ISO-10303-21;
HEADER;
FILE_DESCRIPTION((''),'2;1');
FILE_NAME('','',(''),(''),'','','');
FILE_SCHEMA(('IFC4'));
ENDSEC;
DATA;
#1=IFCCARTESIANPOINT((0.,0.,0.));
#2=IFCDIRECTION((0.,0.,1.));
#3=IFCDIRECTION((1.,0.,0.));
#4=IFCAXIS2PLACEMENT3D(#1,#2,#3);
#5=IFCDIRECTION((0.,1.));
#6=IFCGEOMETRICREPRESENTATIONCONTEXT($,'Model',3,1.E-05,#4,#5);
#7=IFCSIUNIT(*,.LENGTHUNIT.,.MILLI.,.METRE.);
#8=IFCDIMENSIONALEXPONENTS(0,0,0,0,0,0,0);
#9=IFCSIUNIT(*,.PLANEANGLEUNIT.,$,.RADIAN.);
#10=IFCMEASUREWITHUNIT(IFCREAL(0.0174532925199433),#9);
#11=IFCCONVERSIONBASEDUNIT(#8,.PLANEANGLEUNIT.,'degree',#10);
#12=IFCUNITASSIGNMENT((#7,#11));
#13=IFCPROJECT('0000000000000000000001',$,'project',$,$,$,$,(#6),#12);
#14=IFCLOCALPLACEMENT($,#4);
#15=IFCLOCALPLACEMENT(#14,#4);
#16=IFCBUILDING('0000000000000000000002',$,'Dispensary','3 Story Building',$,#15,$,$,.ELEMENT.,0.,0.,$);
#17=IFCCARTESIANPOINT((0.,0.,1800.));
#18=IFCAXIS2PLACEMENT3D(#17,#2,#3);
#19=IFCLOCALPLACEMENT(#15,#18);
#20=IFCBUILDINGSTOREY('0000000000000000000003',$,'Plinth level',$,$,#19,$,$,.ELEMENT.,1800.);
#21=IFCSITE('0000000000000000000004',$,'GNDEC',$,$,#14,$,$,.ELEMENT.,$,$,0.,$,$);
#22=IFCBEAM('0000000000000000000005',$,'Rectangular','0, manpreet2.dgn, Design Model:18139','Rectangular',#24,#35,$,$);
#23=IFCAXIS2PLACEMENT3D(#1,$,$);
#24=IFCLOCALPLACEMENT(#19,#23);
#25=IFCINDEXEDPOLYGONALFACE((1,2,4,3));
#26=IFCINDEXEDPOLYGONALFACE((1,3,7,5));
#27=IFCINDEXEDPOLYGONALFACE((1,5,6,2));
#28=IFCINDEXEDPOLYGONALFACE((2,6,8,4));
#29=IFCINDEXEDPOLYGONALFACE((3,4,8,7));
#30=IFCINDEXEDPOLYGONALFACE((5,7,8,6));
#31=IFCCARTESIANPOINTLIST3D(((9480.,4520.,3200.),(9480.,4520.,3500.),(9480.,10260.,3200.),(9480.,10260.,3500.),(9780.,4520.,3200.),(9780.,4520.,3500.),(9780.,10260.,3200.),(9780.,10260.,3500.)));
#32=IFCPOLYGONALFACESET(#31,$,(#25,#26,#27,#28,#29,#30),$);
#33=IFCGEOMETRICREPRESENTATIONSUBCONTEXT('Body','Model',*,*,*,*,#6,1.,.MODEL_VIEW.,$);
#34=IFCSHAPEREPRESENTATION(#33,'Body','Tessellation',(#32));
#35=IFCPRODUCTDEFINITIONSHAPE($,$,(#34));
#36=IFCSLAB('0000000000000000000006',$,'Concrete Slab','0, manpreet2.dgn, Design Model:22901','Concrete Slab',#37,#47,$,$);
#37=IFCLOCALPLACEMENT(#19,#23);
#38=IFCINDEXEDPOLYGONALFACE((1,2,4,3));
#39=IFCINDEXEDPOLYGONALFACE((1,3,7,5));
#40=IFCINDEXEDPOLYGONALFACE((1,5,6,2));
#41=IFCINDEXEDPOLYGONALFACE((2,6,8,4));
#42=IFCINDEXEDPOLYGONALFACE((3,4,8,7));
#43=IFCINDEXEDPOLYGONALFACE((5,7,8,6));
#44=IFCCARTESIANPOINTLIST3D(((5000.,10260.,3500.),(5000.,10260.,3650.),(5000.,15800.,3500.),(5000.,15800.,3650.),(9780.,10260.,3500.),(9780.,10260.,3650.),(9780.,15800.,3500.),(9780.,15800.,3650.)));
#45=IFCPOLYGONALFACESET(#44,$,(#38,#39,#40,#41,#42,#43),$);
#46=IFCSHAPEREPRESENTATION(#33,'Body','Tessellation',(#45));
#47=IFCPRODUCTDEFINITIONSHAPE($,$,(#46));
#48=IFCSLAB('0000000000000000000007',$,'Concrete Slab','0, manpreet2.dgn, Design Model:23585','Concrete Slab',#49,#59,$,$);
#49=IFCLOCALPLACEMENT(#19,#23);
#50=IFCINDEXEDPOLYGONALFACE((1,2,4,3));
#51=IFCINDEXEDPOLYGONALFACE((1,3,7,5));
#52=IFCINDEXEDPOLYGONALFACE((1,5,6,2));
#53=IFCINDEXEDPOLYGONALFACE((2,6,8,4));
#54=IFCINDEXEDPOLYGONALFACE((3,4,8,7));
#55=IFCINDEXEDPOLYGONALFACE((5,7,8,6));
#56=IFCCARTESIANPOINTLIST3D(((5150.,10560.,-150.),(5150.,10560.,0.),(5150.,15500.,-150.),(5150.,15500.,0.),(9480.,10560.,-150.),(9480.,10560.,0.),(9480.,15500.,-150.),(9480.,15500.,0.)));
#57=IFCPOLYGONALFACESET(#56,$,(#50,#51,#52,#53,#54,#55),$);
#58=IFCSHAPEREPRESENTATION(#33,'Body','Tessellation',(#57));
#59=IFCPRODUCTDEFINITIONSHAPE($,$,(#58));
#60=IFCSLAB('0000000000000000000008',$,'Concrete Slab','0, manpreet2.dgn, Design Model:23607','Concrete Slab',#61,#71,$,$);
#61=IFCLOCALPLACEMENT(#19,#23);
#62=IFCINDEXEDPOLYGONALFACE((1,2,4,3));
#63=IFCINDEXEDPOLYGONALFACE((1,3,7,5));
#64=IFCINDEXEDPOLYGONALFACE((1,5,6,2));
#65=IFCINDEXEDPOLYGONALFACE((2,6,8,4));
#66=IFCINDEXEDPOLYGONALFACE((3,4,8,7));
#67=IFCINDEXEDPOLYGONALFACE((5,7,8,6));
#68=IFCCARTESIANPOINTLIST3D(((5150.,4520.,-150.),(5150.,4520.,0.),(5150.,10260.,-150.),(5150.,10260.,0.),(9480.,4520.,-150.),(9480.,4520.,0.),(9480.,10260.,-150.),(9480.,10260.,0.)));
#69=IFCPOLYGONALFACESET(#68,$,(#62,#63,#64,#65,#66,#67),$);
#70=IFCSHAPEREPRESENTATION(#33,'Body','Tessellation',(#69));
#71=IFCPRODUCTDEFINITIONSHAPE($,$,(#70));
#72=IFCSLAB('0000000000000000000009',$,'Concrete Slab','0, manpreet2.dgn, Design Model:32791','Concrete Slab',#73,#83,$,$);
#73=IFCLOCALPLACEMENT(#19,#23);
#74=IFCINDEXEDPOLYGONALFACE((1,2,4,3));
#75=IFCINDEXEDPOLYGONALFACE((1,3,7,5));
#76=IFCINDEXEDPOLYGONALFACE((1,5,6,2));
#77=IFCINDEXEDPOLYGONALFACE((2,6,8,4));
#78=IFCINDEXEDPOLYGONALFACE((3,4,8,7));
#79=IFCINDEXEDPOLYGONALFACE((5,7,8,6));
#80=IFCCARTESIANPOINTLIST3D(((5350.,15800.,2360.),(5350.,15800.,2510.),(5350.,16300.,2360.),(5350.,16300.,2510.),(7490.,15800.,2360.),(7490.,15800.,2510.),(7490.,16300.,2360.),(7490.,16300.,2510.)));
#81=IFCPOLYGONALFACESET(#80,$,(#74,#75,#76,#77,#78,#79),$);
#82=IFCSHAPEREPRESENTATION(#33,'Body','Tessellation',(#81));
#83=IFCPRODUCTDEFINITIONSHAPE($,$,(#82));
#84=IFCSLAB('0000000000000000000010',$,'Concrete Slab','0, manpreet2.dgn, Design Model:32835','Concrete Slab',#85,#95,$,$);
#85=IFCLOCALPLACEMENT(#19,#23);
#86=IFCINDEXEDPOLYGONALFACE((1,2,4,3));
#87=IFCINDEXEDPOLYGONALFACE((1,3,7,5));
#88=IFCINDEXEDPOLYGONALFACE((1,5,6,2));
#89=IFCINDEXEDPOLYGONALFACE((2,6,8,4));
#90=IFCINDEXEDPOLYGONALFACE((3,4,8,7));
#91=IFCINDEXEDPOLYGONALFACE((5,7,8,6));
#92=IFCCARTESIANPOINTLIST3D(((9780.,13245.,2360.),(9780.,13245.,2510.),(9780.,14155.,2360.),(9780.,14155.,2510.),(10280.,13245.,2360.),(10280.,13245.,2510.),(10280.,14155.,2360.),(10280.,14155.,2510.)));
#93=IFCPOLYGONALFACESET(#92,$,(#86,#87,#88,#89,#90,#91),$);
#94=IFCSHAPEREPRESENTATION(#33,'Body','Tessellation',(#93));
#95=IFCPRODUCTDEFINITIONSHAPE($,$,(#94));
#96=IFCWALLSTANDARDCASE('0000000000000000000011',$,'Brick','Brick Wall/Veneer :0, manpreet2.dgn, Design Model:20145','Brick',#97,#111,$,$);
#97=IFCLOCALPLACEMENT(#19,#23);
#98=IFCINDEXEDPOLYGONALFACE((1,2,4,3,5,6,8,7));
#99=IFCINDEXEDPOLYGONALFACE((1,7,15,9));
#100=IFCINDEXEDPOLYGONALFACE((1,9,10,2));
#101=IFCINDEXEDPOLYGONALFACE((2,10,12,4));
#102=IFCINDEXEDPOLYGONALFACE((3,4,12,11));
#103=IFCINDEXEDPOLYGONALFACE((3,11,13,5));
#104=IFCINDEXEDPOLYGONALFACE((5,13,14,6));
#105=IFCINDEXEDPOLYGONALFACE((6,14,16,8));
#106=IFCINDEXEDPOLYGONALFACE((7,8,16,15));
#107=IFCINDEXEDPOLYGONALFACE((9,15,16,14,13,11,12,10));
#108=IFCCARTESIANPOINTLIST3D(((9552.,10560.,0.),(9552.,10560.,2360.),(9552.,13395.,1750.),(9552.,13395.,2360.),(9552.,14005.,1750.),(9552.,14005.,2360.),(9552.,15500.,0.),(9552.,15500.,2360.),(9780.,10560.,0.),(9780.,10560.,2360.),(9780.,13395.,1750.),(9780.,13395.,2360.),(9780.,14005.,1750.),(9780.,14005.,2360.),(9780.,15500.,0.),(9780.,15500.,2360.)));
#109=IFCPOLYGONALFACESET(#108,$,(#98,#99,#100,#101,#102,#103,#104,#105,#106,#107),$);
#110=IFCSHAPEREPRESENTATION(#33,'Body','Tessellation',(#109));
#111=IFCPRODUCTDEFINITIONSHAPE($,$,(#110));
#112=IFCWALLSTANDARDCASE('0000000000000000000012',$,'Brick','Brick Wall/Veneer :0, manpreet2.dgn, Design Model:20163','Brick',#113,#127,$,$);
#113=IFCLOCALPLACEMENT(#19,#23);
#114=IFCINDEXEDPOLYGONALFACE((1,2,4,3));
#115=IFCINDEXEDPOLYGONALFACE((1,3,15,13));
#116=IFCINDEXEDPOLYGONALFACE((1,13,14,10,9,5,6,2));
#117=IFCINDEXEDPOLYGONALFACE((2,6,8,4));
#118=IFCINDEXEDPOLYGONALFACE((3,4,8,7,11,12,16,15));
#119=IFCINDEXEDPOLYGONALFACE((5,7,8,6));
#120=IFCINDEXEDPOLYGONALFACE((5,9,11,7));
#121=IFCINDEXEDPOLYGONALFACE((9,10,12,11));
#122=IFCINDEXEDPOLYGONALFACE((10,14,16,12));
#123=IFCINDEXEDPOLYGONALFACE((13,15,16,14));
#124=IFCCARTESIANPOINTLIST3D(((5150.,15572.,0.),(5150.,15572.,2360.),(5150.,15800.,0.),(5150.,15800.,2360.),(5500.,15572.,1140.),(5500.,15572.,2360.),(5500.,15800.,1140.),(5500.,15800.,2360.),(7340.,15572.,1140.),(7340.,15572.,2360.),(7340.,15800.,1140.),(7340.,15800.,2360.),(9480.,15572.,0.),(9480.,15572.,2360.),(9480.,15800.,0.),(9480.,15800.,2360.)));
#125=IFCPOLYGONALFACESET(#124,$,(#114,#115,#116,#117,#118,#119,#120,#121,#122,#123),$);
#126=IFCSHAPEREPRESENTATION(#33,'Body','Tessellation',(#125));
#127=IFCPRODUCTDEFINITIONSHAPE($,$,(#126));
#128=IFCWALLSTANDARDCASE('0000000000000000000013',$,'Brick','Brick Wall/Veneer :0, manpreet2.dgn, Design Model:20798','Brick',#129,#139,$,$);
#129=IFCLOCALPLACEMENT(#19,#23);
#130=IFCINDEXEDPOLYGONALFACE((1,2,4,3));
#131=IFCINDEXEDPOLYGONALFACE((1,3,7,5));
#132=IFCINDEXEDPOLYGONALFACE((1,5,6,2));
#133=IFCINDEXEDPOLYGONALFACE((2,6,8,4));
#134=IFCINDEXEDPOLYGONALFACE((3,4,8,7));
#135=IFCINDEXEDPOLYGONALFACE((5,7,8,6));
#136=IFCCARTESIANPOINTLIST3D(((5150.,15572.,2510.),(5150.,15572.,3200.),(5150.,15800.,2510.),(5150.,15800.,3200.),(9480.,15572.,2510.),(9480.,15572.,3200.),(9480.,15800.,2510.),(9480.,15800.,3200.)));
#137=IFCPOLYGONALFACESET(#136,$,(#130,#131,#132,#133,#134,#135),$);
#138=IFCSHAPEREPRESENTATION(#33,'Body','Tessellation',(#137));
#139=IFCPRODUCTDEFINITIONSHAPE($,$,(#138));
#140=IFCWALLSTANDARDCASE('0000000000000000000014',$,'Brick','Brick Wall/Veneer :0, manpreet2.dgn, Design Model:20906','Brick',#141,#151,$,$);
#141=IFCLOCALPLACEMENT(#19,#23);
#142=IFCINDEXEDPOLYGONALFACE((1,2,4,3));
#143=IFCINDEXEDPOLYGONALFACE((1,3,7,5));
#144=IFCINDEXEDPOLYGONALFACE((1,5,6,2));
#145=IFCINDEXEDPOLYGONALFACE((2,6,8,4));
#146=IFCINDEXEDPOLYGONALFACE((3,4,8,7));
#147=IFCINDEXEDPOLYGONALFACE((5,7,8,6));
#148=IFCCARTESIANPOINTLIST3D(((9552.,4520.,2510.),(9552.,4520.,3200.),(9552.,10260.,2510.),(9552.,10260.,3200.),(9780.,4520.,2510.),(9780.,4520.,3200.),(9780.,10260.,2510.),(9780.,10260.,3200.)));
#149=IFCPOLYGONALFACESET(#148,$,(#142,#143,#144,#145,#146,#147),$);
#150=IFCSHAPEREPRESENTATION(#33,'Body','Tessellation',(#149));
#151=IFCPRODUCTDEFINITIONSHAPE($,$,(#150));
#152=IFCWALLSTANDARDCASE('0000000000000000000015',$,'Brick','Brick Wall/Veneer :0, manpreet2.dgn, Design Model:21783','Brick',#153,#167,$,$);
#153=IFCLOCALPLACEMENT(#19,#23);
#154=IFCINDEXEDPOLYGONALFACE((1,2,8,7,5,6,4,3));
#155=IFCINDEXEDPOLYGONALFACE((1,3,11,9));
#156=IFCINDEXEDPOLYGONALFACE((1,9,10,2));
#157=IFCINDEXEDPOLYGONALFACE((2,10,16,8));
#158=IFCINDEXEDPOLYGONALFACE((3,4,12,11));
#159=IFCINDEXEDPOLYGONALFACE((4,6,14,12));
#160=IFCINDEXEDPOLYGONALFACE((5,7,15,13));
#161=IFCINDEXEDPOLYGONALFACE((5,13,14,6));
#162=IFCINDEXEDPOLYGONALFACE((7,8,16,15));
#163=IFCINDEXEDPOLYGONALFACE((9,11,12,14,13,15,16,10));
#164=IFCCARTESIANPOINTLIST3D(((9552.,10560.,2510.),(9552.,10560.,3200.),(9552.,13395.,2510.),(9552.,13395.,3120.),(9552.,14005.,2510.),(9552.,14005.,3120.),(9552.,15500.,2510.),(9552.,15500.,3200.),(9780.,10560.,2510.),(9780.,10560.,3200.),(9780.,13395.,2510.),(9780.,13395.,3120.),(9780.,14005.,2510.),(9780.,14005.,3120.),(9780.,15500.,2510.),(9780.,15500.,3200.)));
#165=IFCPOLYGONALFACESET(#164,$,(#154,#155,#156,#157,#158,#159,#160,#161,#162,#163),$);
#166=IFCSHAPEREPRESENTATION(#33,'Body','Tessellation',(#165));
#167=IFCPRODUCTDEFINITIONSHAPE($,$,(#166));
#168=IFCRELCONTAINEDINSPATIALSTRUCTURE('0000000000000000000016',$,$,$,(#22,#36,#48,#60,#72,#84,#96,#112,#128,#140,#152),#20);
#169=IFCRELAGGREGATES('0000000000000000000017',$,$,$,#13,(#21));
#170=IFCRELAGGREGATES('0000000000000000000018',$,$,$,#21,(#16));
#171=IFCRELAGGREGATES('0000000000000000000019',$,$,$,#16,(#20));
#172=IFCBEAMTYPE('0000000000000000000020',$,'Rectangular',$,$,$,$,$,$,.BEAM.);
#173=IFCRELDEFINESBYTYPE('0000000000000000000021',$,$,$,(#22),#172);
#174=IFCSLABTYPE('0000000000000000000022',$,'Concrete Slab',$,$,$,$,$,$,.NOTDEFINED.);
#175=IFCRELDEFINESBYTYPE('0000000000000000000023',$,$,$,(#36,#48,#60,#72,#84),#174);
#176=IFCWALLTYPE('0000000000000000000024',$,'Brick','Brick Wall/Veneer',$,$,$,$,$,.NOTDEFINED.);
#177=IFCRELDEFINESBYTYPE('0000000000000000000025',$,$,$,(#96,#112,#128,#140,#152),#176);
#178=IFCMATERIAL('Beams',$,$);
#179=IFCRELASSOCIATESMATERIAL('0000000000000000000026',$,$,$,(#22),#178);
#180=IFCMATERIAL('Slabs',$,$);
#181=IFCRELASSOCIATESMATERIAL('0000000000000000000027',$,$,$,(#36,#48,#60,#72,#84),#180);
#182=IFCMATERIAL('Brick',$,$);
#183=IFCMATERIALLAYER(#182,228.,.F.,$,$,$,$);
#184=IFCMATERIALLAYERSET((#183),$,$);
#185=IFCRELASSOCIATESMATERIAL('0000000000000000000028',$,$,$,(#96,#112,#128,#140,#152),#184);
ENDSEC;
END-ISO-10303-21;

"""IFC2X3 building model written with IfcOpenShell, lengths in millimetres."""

from ifc_helpers import new_model, entity, si_unit, converted_unit, direction, frame, frame_2d, origin_with_axes, place, context, subcontext, project, spatial, rectangle, extrude, material, layer, layer_set, layer_usage, type_object, element, save


model = new_model("IFC2X3")

# Units and contexts
model_context = context("Model", 3, precision=1e-05, world=origin_with_axes(), true_north=direction((0.0, 1.0)))
body_context = subcontext(model_context, "Body", "Model", "MODEL_VIEW", scale=1.0)
ifc_project = project(units=[si_unit("LENGTHUNIT", "METRE", prefix="MILLI"), converted_unit("PLANEANGLEUNIT", "degree", entity("IfcReal", 0.0174532925199433), si_unit("PLANEANGLEUNIT", "RADIAN"), dimensions=[0, 0, 0, 0, 0, 0, 0])], contexts=[model_context])

# Site, building, storey
site_placement = place(None, origin_with_axes())
site = spatial("IfcSite", under=ifc_project, at=site_placement, Name="GNDEC", CompositionType="ELEMENT", RefElevation=0.0)
building_placement = place(site_placement, origin_with_axes())
building = spatial("IfcBuilding", under=site, at=building_placement, Name="Dispensary", Description="3 Story Building", CompositionType="ELEMENT", ElevationOfRefHeight=0.0, ElevationOfTerrain=0.0)
storey_placement = place(building_placement, frame((0.0, 0.0, 1800.0), z_axis=(0.0, 0.0, 1.0), x_axis=(1.0, 0.0, 0.0)))
storey = spatial("IfcBuildingStorey", under=building, at=storey_placement, Name="Plinth level", CompositionType="ELEMENT", Elevation=1800.0)

# Beam
ifc_material_1 = material(Name="Beams")
beam_type = type_object("IfcBeamType", Name="Rectangular", PredefinedType="BEAM")
beam_1_placement = place(storey_placement, frame((9480.0, 10260.0, 3200.0), z_axis=(0.0, -1.0, 0.0), x_axis=(1.0, 0.0, 0.0)))
element("IfcBeam", 1, at=beam_1_placement, inside=storey, type_object=beam_type, material=ifc_material_1, Name="Rectangular", Description="0, manpreet2.dgn, Design Model:18139", ObjectType="Rectangular", context=body_context, shape_type="SweptSolid", body=[
    extrude(rectangle(XDim=300.0, YDim=300.0, at=frame_2d((150.0, 150.0), x_axis=(0.0, 1.0))), origin_with_axes(), (0.0, 0.0, 1.0), 5740.0),
])

# Slabs
ifc_material_2 = material(Name="Slabs")
slab_type = type_object("IfcSlabType", Name="Concrete Slab", PredefinedType="NOTDEFINED")
slab_1_placement = place(storey_placement, frame((5000.0, 10260.0, 3500.0), z_axis=(0.0, 0.0, 1.0), x_axis=(1.0, 0.0, 0.0)))
element("IfcSlab", 2, at=slab_1_placement, inside=storey, type_object=slab_type, material=ifc_material_2, Name="Concrete Slab", Description="0, manpreet2.dgn, Design Model:22901", ObjectType="Concrete Slab", context=body_context, shape_type="SweptSolid", body=[
    extrude(rectangle(XDim=4780.0, YDim=5540.0, at=frame_2d((2390.0, 2770.0), x_axis=(1.0, 0.0))), origin_with_axes(), (0.0, 0.0, 1.0), 150.0),
])
slab_2_placement = place(storey_placement, frame((5150.0, 15500.0, 0.0), z_axis=(0.0, 0.0, -1.0), x_axis=(1.0, 0.0, 0.0)))
element("IfcSlab", 3, at=slab_2_placement, inside=storey, type_object=slab_type, material=ifc_material_2, Name="Concrete Slab", Description="0, manpreet2.dgn, Design Model:23585", ObjectType="Concrete Slab", context=body_context, shape_type="SweptSolid", body=[
    extrude(rectangle(XDim=4330.0, YDim=4940.0, at=frame_2d((2165.0, 2470.0), x_axis=(1.0, 0.0))), origin_with_axes(), (0.0, 0.0, 1.0), 150.0),
])
slab_3_placement = place(storey_placement, frame((5150.0, 10260.0, 0.0), z_axis=(0.0, 0.0, -1.0), x_axis=(1.0, 0.0, 0.0)))
element("IfcSlab", 4, at=slab_3_placement, inside=storey, type_object=slab_type, material=ifc_material_2, Name="Concrete Slab", Description="0, manpreet2.dgn, Design Model:23607", ObjectType="Concrete Slab", context=body_context, shape_type="SweptSolid", body=[
    extrude(rectangle(XDim=4330.0, YDim=5740.0, at=frame_2d((2165.0, 2870.0), x_axis=(1.0, 0.0))), origin_with_axes(), (0.0, 0.0, 1.0), 150.0),
])
slab_4_placement = place(storey_placement, frame((5500.0, 15800.0, 2510.0), z_axis=(0.0, 0.0, -1.0), x_axis=(-1.0, 0.0, 0.0)))
element("IfcSlab", 5, at=slab_4_placement, inside=storey, type_object=slab_type, material=ifc_material_2, Name="Concrete Slab", Description="0, manpreet2.dgn, Design Model:32791", ObjectType="Concrete Slab", context=body_context, shape_type="SweptSolid", body=[
    extrude(rectangle(XDim=500.0, YDim=2140.0, at=frame_2d((-920.0, 250.0), x_axis=(0.0, 1.0))), origin_with_axes(), (0.0, 0.0, 1.0), 150.0),
])
slab_5_placement = place(storey_placement, frame((9780.0, 14005.0, 2510.0), z_axis=(0.0, 0.0, -1.0), x_axis=(0.0, 1.0, 0.0)))
element("IfcSlab", 6, at=slab_5_placement, inside=storey, type_object=slab_type, material=ifc_material_2, Name="Concrete Slab", Description="0, manpreet2.dgn, Design Model:32835", ObjectType="Concrete Slab", context=body_context, shape_type="SweptSolid", body=[
    extrude(rectangle(XDim=500.0, YDim=910.0, at=frame_2d((-305.0, 250.0), x_axis=(0.0, 1.0))), origin_with_axes(), (0.0, 0.0, 1.0), 150.0),
])

# Walls, openings
ifc_material_3 = material(Name="Brick")
ifc_layer_1 = layer(ifc_material_3, 228.0, ventilated=False)
ifc_layer_set_1 = layer_set([ifc_layer_1])
ifc_layer_usage_1 = layer_usage(ifc_layer_set_1, "AXIS2", "POSITIVE", 0.0)
wall_type = type_object("IfcWallType", Name="Brick", Description="Brick Wall/Veneer", PredefinedType="NOTDEFINED")
wall_1_placement = place(storey_placement, frame((9780.0, 10560.0, 0.0), z_axis=(0.0, 0.0, 1.0), x_axis=(0.0, 1.0, 0.0)))
wall_1 = element("IfcWallStandardCase", 7, at=wall_1_placement, inside=storey, type_object=wall_type, material=ifc_layer_usage_1, Name="Brick", Description="Brick Wall/Veneer :0, manpreet2.dgn, Design Model:20145", ObjectType="Brick", context=body_context, shape_type="SweptSolid", body=[
    extrude(rectangle(XDim=4940.0, YDim=228.0, at=frame_2d((2470.0, 114.0), x_axis=(-1.0, 0.0))), origin_with_axes(), (0.0, 0.0, 1.0), 2360.0),
])
opening_1_placement = place(wall_1_placement, frame((2835.0, 0.0, 1750.0), z_axis=(0.0, 0.0, 1.0), x_axis=(1.0, 0.0, 0.0)))
element("IfcOpeningElement", 8, at=opening_1_placement, cuts=wall_1, ObjectType="Opening", context=body_context, shape_type="SweptSolid", body=[
    extrude(rectangle(XDim=1370.0, YDim=610.0, at=frame_2d((-305.0, 685.0), x_axis=(0.0, -1.0))), frame((0.0, 0.0, 0.0), z_axis=(0.0, 1.0, 0.0), x_axis=(-1.0, 0.0, 0.0)), (0.0, 0.0, 1.0), 228.0),
])
wall_2_placement = place(storey_placement, frame((9480.0, 15800.0, 0.0), z_axis=(0.0, 0.0, 1.0), x_axis=(-1.0, 0.0, 0.0)))
wall_2 = element("IfcWallStandardCase", 9, at=wall_2_placement, inside=storey, type_object=wall_type, material=ifc_layer_usage_1, Name="Brick", Description="Brick Wall/Veneer :0, manpreet2.dgn, Design Model:20163", ObjectType="Brick", context=body_context, shape_type="SweptSolid", body=[
    extrude(rectangle(XDim=4330.0, YDim=228.0, at=frame_2d((2165.0, 114.0), x_axis=(-1.0, 0.0))), origin_with_axes(), (0.0, 0.0, 1.0), 2360.0),
])
opening_2_placement = place(wall_2_placement, frame((2140.0, 0.0, 1140.0), z_axis=(0.0, 0.0, 1.0), x_axis=(1.0, 0.0, 0.0)))
element("IfcOpeningElement", 10, at=opening_2_placement, cuts=wall_2, ObjectType="Opening", context=body_context, shape_type="SweptSolid", body=[
    extrude(rectangle(XDim=1220.0, YDim=1840.0, at=frame_2d((-920.0, 610.0), x_axis=(0.0, -1.0))), frame((0.0, 0.0, 0.0), z_axis=(0.0, 1.0, 0.0), x_axis=(-1.0, 0.0, 0.0)), (0.0, 0.0, 1.0), 228.0),
])

# Walls
wall_3_placement = place(storey_placement, frame((5150.0, 15800.0, 2510.0), z_axis=(0.0, 0.0, 1.0), x_axis=(1.0, 0.0, 0.0)))
element("IfcWallStandardCase", 11, at=wall_3_placement, inside=storey, type_object=wall_type, material=ifc_layer_usage_1, Name="Brick", Description="Brick Wall/Veneer :0, manpreet2.dgn, Design Model:20798", ObjectType="Brick", context=body_context, shape_type="SweptSolid", body=[
    extrude(rectangle(XDim=4330.0, YDim=228.0, at=frame_2d((2165.0, -114.0), x_axis=(-1.0, 0.0))), origin_with_axes(), (0.0, 0.0, 1.0), 690.0),
])
wall_4_placement = place(storey_placement, frame((9780.0, 10260.0, 2510.0), z_axis=(0.0, 0.0, 1.0), x_axis=(0.0, -1.0, 0.0)))
element("IfcWallStandardCase", 12, at=wall_4_placement, inside=storey, type_object=wall_type, material=ifc_layer_usage_1, Name="Brick", Description="Brick Wall/Veneer :0, manpreet2.dgn, Design Model:20906", ObjectType="Brick", context=body_context, shape_type="SweptSolid", body=[
    extrude(rectangle(XDim=5740.0, YDim=228.0, at=frame_2d((2870.0, -114.0), x_axis=(-1.0, 0.0))), origin_with_axes(), (0.0, 0.0, 1.0), 690.0),
])

# Wall, opening
wall_5_placement = place(storey_placement, frame((9780.0, 15500.0, 2510.0), z_axis=(0.0, 0.0, 1.0), x_axis=(0.0, -1.0, 0.0)))
wall_5 = element("IfcWallStandardCase", 13, at=wall_5_placement, inside=storey, type_object=wall_type, material=ifc_layer_usage_1, Name="Brick", Description="Brick Wall/Veneer :0, manpreet2.dgn, Design Model:21783", ObjectType="Brick", context=body_context, shape_type="SweptSolid", body=[
    extrude(rectangle(XDim=4940.0, YDim=228.0, at=frame_2d((2470.0, -114.0), x_axis=(-1.0, 0.0))), origin_with_axes(), (0.0, 0.0, 1.0), 690.0),
])
opening_3_placement = place(wall_5_placement, frame((1495.0, -228.0, -760.0), z_axis=(0.0, 0.0, 1.0), x_axis=(1.0, 0.0, 0.0)))
element("IfcOpeningElement", 14, at=opening_3_placement, cuts=wall_5, ObjectType="Opening", context=body_context, shape_type="SweptSolid", body=[
    extrude(rectangle(XDim=1370.0, YDim=610.0, at=frame_2d((-305.0, 685.0), x_axis=(0.0, -1.0))), frame((0.0, 0.0, 0.0), z_axis=(0.0, 1.0, 0.0), x_axis=(-1.0, 0.0, 0.0)), (0.0, 0.0, 1.0), 228.0),
])

save(model, "model.ifc")
